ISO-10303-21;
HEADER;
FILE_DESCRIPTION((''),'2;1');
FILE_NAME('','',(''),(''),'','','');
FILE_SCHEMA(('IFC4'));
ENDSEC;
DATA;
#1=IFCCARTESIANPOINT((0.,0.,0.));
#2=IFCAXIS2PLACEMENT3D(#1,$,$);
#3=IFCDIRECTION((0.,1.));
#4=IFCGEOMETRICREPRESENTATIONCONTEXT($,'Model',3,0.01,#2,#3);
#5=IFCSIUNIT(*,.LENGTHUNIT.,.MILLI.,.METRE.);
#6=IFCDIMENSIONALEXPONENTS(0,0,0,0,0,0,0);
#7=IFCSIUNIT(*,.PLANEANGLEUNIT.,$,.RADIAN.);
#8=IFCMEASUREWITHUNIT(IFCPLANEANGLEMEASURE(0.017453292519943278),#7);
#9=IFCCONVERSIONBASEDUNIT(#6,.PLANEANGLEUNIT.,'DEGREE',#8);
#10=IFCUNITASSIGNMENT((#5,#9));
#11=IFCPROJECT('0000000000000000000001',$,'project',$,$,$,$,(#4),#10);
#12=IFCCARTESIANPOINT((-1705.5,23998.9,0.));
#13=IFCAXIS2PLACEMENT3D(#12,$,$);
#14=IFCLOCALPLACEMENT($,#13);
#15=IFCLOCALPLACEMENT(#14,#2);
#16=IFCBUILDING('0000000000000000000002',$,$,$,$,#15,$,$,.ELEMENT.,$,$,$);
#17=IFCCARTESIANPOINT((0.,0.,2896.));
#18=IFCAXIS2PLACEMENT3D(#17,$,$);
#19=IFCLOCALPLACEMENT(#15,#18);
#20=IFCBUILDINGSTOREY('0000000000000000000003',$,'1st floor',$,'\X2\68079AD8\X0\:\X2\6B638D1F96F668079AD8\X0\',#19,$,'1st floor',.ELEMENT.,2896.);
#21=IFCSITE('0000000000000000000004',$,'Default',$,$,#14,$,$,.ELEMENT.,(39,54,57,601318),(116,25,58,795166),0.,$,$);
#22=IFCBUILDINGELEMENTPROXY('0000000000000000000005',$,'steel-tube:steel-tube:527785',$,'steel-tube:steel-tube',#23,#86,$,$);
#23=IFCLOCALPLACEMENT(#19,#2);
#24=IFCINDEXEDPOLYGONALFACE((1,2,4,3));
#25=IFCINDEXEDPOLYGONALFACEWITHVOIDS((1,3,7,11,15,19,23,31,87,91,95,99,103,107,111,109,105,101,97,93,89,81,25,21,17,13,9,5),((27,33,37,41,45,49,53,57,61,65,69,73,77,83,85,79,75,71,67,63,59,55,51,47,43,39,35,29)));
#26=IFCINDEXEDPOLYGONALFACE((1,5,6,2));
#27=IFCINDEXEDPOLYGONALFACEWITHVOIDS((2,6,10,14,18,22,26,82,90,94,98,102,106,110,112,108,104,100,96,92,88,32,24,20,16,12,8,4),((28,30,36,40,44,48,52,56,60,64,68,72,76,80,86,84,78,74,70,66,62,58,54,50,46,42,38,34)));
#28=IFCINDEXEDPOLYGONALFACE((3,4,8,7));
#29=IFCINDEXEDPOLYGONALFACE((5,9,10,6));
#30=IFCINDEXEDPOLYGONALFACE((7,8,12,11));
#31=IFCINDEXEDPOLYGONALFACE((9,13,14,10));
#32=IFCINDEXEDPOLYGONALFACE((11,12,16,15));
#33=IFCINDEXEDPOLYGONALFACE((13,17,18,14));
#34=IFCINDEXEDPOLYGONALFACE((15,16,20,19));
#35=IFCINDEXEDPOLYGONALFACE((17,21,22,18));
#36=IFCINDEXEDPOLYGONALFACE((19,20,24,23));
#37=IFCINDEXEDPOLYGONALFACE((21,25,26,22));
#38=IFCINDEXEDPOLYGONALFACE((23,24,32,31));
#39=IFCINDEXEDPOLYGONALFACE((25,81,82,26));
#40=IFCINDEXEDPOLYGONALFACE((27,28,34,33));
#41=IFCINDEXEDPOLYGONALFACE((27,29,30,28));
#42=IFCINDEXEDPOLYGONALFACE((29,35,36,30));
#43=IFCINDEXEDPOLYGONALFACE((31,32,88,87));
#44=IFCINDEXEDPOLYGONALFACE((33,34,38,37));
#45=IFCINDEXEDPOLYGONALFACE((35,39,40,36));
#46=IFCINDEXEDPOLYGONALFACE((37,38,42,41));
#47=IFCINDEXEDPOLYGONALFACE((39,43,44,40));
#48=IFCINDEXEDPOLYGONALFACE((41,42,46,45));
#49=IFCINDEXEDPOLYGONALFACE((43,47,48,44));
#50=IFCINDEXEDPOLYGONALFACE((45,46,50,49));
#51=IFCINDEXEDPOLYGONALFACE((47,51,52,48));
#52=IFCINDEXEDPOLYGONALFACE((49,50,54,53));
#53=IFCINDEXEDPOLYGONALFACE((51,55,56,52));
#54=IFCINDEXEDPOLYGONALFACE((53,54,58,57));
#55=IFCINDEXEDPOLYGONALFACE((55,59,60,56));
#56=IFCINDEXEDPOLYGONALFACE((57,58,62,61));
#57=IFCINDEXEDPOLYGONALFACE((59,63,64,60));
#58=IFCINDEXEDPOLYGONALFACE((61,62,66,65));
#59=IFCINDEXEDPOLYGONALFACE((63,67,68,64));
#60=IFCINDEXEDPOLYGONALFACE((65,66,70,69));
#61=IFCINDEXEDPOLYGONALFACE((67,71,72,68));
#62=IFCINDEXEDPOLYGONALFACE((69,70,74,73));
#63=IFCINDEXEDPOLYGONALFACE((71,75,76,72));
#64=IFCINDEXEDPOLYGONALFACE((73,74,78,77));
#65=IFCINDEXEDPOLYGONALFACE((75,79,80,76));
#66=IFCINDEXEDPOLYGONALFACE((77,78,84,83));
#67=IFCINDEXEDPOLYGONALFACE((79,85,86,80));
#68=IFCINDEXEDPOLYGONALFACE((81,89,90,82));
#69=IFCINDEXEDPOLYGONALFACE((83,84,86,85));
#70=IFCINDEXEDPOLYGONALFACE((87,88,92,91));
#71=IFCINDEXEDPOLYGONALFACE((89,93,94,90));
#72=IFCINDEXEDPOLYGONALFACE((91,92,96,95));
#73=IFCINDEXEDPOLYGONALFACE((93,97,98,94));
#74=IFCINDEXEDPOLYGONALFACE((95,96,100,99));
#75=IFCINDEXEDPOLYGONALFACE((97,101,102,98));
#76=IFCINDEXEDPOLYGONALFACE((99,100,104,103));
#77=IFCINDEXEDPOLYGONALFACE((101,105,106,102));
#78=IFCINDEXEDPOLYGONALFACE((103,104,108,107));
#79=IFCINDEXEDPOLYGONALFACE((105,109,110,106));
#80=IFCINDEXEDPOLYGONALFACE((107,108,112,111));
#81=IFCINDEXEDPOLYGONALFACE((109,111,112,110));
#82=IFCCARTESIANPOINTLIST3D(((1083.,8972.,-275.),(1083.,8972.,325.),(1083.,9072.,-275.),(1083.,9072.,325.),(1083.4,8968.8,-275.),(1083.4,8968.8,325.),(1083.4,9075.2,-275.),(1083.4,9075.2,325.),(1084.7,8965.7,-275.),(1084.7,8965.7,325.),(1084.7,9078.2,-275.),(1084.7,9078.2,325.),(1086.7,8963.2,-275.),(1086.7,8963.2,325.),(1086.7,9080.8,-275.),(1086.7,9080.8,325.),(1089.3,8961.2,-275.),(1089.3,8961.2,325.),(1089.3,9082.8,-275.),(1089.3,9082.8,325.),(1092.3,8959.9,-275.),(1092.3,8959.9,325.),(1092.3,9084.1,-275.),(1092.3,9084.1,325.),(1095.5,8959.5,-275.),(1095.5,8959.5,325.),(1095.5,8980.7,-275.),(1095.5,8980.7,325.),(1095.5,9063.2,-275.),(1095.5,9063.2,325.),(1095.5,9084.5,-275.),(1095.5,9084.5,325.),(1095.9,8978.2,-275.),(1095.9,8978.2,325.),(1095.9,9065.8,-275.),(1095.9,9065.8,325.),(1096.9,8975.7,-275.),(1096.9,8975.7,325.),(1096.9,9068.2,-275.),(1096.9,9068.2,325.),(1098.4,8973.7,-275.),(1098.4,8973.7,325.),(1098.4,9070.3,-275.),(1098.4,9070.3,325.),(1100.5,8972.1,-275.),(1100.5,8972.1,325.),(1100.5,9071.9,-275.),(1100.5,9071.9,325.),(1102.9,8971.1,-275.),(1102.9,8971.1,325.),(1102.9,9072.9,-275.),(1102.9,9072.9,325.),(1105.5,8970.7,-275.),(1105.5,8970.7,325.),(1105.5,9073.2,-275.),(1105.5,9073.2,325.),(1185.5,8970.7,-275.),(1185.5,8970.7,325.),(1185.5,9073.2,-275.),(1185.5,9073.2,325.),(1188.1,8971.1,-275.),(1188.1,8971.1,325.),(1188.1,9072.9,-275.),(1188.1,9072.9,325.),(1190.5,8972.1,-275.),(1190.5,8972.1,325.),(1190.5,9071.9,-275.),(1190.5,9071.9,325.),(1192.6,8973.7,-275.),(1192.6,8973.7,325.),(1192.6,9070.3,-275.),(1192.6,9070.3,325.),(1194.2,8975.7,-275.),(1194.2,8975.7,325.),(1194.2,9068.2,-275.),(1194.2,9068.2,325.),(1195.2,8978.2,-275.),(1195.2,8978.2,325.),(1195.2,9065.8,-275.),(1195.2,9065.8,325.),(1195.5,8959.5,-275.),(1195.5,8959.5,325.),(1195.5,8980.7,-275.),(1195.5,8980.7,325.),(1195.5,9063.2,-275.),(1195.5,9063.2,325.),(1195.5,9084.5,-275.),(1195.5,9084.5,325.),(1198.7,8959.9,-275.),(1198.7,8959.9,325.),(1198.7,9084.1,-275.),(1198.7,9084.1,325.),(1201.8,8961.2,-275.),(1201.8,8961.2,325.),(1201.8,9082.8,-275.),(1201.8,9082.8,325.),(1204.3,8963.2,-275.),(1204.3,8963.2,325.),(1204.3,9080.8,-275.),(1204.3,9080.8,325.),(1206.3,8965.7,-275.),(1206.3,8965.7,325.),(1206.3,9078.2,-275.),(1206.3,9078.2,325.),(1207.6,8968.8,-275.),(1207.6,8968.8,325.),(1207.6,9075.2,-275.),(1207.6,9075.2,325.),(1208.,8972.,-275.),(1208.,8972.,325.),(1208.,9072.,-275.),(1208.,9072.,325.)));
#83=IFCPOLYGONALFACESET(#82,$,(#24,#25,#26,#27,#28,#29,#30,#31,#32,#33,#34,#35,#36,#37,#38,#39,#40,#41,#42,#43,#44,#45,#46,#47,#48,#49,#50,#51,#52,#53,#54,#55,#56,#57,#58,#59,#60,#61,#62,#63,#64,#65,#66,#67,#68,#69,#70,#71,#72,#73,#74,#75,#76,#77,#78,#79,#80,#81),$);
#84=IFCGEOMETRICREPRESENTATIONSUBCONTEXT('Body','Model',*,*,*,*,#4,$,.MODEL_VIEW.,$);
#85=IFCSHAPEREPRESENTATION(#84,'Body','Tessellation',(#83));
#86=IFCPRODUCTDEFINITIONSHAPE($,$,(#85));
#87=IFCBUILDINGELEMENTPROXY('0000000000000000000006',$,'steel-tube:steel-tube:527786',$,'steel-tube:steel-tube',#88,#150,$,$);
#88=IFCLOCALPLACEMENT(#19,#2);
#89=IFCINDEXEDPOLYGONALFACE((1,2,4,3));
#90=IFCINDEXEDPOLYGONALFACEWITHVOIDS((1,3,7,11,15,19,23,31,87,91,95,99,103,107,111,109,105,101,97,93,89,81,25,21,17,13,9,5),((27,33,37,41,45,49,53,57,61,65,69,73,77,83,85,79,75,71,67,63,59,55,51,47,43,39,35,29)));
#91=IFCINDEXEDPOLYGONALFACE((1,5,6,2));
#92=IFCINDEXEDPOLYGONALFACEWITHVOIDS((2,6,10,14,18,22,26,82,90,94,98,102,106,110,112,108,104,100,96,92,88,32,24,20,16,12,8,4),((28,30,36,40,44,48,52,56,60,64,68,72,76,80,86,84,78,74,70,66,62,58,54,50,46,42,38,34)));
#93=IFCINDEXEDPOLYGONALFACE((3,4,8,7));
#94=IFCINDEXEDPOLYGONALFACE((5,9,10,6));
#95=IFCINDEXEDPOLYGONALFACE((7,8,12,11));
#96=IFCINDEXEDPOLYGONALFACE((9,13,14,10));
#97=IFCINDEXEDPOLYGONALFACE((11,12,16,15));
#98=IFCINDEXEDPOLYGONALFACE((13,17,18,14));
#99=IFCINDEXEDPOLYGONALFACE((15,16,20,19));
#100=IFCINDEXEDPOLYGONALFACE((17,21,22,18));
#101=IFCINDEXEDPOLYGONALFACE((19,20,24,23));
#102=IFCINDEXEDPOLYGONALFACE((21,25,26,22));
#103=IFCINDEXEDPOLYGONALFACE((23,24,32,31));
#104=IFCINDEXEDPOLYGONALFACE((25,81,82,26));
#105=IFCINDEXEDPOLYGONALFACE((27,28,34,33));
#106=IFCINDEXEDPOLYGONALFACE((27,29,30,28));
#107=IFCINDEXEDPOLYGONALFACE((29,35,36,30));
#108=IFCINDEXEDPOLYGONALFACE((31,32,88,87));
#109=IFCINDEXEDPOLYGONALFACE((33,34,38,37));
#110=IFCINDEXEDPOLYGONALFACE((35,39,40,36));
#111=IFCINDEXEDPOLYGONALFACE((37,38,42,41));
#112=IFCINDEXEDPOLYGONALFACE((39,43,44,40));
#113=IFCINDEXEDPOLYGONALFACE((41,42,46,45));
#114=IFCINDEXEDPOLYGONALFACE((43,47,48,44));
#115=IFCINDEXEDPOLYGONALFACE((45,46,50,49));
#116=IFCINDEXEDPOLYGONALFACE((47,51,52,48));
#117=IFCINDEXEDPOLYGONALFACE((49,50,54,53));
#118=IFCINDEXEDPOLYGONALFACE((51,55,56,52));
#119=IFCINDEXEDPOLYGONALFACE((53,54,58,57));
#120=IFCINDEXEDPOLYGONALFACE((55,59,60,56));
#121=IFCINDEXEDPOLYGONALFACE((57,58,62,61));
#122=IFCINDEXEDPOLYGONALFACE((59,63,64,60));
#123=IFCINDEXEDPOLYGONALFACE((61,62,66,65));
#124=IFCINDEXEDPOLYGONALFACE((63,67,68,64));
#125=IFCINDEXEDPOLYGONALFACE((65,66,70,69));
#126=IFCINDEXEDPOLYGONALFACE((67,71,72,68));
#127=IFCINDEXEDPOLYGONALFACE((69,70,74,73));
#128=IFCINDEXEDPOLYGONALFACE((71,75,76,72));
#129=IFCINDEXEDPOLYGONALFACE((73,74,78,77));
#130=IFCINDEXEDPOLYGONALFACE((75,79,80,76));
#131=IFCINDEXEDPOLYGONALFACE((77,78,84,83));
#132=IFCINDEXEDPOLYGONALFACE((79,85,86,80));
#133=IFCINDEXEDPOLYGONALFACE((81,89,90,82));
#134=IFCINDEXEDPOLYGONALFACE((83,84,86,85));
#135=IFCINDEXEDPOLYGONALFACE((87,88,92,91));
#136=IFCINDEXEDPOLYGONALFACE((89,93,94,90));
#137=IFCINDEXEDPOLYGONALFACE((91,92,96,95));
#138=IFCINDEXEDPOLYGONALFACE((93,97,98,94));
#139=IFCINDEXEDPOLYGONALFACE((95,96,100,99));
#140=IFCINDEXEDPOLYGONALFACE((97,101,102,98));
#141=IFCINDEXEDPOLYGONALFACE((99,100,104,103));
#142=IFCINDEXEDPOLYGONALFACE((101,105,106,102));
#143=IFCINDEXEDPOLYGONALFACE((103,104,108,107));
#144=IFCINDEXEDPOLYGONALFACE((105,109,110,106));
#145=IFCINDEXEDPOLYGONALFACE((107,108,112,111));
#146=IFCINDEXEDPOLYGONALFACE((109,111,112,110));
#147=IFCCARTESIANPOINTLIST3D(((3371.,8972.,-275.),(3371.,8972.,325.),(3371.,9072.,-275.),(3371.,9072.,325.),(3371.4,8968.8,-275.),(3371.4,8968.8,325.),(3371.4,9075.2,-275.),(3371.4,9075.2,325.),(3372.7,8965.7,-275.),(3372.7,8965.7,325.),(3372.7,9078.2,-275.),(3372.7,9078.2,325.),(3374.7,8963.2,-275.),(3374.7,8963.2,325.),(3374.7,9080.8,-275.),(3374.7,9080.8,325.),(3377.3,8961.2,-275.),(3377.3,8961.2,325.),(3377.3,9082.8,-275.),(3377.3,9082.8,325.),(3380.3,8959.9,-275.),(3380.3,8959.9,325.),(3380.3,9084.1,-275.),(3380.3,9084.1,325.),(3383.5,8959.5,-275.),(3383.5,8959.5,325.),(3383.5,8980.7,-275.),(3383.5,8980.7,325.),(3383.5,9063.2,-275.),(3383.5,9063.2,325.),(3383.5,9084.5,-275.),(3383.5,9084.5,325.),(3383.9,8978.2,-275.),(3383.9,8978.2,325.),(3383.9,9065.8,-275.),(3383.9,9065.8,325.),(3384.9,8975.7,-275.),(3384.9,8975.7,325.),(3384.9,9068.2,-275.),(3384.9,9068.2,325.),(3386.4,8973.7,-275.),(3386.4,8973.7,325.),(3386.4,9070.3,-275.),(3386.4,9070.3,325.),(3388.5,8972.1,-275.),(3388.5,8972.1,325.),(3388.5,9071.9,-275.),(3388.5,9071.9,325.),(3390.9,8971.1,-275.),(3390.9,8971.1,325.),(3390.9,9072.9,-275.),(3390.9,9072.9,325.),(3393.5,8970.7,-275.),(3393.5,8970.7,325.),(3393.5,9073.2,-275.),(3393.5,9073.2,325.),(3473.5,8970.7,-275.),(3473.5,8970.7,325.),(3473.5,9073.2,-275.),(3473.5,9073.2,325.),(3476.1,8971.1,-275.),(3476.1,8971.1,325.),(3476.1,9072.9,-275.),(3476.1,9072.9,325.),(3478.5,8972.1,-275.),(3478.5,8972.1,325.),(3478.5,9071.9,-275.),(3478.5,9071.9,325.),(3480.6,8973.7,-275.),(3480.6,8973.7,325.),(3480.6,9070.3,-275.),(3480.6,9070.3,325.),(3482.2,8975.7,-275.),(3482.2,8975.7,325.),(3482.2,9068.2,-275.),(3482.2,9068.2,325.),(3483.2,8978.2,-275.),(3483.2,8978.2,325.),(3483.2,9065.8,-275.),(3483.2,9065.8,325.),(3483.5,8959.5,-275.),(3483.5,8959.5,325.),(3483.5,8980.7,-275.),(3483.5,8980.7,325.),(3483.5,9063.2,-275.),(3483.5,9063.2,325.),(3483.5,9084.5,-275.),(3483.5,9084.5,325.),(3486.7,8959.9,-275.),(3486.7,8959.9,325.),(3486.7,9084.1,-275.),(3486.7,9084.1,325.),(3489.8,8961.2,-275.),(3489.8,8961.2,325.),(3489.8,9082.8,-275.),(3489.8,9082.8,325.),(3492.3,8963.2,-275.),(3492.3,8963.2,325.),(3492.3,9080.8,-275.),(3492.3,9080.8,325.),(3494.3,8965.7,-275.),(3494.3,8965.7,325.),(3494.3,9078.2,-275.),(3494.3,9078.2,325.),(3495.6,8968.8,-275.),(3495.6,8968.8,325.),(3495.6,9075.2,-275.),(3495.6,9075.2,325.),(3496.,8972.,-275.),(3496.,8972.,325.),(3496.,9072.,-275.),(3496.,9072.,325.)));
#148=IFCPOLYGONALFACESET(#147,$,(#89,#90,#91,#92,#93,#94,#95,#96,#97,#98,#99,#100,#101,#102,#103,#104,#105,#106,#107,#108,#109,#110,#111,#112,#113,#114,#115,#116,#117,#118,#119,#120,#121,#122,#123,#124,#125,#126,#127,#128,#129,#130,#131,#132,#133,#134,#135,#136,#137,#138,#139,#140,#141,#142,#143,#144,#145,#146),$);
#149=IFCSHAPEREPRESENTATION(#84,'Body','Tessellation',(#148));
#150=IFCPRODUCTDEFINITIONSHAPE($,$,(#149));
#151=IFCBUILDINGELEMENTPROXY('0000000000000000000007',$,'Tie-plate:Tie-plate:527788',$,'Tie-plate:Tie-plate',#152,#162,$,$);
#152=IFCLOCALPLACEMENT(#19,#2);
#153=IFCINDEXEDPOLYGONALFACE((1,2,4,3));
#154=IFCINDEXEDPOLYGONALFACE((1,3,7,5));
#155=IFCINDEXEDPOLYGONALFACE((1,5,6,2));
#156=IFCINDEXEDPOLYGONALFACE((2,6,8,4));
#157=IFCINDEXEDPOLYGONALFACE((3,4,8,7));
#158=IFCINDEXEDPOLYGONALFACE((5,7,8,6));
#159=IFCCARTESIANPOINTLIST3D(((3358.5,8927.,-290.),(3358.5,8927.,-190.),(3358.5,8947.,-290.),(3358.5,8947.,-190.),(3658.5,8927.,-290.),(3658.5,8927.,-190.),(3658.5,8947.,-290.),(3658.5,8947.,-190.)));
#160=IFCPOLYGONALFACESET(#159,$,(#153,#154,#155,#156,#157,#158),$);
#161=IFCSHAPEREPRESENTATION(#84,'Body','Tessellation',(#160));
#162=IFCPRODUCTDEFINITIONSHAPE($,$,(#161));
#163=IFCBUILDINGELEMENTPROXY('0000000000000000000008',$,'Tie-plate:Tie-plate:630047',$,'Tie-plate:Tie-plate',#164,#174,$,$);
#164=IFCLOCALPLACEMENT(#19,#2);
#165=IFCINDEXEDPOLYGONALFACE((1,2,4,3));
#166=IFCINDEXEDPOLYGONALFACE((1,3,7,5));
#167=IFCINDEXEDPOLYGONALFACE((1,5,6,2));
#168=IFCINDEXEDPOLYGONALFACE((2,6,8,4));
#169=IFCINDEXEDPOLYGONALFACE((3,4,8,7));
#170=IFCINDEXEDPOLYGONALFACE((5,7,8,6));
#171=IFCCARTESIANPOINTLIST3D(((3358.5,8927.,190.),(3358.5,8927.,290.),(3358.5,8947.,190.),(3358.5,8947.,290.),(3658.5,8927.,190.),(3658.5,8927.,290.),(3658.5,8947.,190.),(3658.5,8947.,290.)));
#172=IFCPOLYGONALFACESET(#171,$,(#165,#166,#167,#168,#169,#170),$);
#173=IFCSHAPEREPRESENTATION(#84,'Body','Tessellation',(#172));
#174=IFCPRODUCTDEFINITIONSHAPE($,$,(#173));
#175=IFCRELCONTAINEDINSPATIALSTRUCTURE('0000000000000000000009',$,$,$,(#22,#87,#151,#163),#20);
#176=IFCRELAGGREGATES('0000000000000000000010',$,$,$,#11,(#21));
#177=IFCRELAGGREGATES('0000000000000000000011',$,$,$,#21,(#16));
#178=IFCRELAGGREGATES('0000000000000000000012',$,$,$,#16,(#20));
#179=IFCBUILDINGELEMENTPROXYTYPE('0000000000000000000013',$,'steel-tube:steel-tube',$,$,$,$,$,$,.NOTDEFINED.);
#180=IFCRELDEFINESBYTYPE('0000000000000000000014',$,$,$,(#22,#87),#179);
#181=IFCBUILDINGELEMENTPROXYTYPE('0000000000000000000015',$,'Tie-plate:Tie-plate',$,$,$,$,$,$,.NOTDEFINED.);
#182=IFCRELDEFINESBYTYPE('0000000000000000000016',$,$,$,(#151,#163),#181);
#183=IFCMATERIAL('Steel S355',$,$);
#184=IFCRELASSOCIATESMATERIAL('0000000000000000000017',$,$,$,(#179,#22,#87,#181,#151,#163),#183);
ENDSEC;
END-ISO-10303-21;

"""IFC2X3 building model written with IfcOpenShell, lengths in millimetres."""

from ifc_helpers import new_model, entity, si_unit, converted_unit, direction, frame, frame_2d, origin, place, context, subcontext, project, spatial, polyline, circle_curve, parameter, trimmed, segment, composite_curve, rectangle, outline, extrude, source, transform, mapped, material, type_object, type_shapes, element, save


model = new_model("IFC2X3")

# Units and contexts
model_context = context("Model", 3, precision=0.01, world=origin(), true_north=direction((0.0, 1.0)))
body_context = subcontext(model_context, "Body", "Model", "MODEL_VIEW")
ifc_project = project(units=[si_unit("LENGTHUNIT", "METRE", prefix="MILLI"), converted_unit("PLANEANGLEUNIT", "DEGREE", entity("IfcPlaneAngleMeasure", 0.017453292519943278), si_unit("PLANEANGLEUNIT", "RADIAN"), dimensions=[0, 0, 0, 0, 0, 0, 0])], contexts=[model_context])

# Site, building, storey
site_placement = place(None, frame((-1705.5, 23998.9, 0.0)))
site = spatial("IfcSite", under=ifc_project, at=site_placement, Name="Default", CompositionType="ELEMENT", RefLatitude=(39, 54, 57, 601318), RefLongitude=(116, 25, 58, 795166), RefElevation=0.0)
building_placement = place(site_placement, origin())
building = spatial("IfcBuilding", under=site, at=building_placement, CompositionType="ELEMENT")
storey_placement = place(building_placement, frame((0.0, 0.0, 2896.0)))
storey = spatial("IfcBuildingStorey", under=building, at=storey_placement, Name="1st floor", ObjectType="标高:正负零标高", LongName="1st floor", CompositionType="ELEMENT", Elevation=2896.0)

# Shared definitions
ifc_material_1 = material(Name="Steel S355")

# Building element proxies
building_element_proxy_type_1 = type_object("IfcBuildingElementProxyType", Name="steel-tube:steel-tube", PredefinedType="NOTDEFINED", material=ifc_material_1)
shared_shape_1 = source(origin(), body_context, "Body", "SweptSolid", [
    extrude(outline(composite_curve([segment(trimmed(circle_curve(frame_2d((50.0, -50.0), x_axis=(1.0, 0.0)), 12.5), [parameter(270.0)], [parameter(0.0)], True, "PARAMETER"), True, "CONTINUOUS"), segment(polyline([(62.5, -50.0), (62.5, 50.0)]), True, "CONTINUOUS"), segment(trimmed(circle_curve(frame_2d((50.0, 50.0), x_axis=(1.0, 0.0)), 12.5), [parameter(0.0)], [parameter(90.0)], True, "PARAMETER"), True, "CONTINUOUS"), segment(polyline([(50.0, 62.5), (-50.0, 62.5)]), True, "CONTINUOUS"), segment(trimmed(circle_curve(frame_2d((-50.0, 50.0), x_axis=(1.0, 0.0)), 12.5), [parameter(90.0)], [parameter(180.0)], True, "PARAMETER"), True, "CONTINUOUS"), segment(polyline([(-62.5, 50.0), (-62.5, -50.0)]), True, "CONTINUOUS"), segment(trimmed(circle_curve(frame_2d((-50.0, -50.0), x_axis=(1.0, 0.0)), 12.5), [parameter(180.0)], [parameter(270.0)], True, "PARAMETER"), True, "CONTINUOUS"), segment(polyline([(-50.0, -62.5), (50.0, -62.5)]), True, "CONTINUOUS")], self_intersect=False), holes=[composite_curve([segment(trimmed(circle_curve(frame_2d((-41.2, 40.0), x_axis=(1.0, 0.0)), 10.0), [parameter(90.0)], [parameter(180.0)], True, "PARAMETER"), False, "CONTINUOUS"), segment(polyline([(-41.3, 50.0), (41.2, 50.0)]), True, "CONTINUOUS"), segment(trimmed(circle_curve(frame_2d((41.2, 40.0), x_axis=(1.0, 0.0)), 10.0), [parameter(0.0)], [parameter(90.0)], True, "PARAMETER"), False, "CONTINUOUS"), segment(polyline([(51.2, 40.0), (51.2, -40.0)]), True, "CONTINUOUS"), segment(trimmed(circle_curve(frame_2d((41.2, -40.0), x_axis=(1.0, 0.0)), 10.0), [parameter(270.0)], [parameter(360.0)], True, "PARAMETER"), False, "CONTINUOUS"), segment(polyline([(41.2, -50.0), (-41.3, -50.0)]), True, "CONTINUOUS"), segment(trimmed(circle_curve(frame_2d((-41.3, -40.0), x_axis=(1.0, 0.0)), 10.0), [parameter(180.0)], [parameter(270.0)], True, "PARAMETER"), False, "CONTINUOUS"), segment(polyline([(-51.3, -40.0), (-51.3, 40.0)]), True, "CONTINUOUS")], self_intersect=False)]), frame((62.5, 62.5, -175.0)), (0.0, 0.0, 1.0), 600.0),
])
type_shapes(building_element_proxy_type_1, [shared_shape_1])
for number, where, z_axis, x_axis, name in (
    (1, (1083.0, 9084.5, -100.0), (0.0, 0.0, 1.0), (0.0, -1.0, 0.0), "steel-tube:steel-tube:527785"),
    (2, (3371.0, 9084.5, -100.0), (0.0, 0.0, 1.0), (0.0, -1.0, 0.0), "steel-tube:steel-tube:527786"),
):
    element("IfcBuildingElementProxy", number, at=place(storey_placement, frame(where, z_axis=z_axis, x_axis=x_axis)), inside=storey, type_object=building_element_proxy_type_1, material=ifc_material_1, Name=name, ObjectType="steel-tube:steel-tube", context=body_context, shape_type="MappedRepresentation", body=[
        mapped(shared_shape_1, transform((0.0, 0.0, 0.0), scale=1.0)),
    ])
building_element_proxy_type_2 = type_object("IfcBuildingElementProxyType", Name="Tie-plate:Tie-plate", PredefinedType="NOTDEFINED", material=ifc_material_1)
shared_shape_2 = source(origin(), body_context, "Body", "SweptSolid", [
    extrude(rectangle(XDim=300.0, YDim=20.0, at=frame_2d((0.0, 0.0), x_axis=(1.0, 0.0))), frame((150.0, -10.0, 0.0), z_axis=(0.0, 0.0, 1.0), x_axis=(-1.0, 0.0, 0.0)), (0.0, 0.0, 1.0), 100.0),
])
type_shapes(building_element_proxy_type_2, [shared_shape_2])
for number, where, name in (
    (3, (3358.5, 8947.0, -290.0), "Tie-plate:Tie-plate:527788"),
    (4, (3358.5, 8947.0, 190.0), "Tie-plate:Tie-plate:630047"),
):
    element("IfcBuildingElementProxy", number, at=place(storey_placement, frame(where)), inside=storey, type_object=building_element_proxy_type_2, material=ifc_material_1, Name=name, ObjectType="Tie-plate:Tie-plate", context=body_context, shape_type="MappedRepresentation", body=[
        mapped(shared_shape_2, transform((0.0, 0.0, 0.0), scale=1.0)),
    ])

save(model, "model.ifc")
